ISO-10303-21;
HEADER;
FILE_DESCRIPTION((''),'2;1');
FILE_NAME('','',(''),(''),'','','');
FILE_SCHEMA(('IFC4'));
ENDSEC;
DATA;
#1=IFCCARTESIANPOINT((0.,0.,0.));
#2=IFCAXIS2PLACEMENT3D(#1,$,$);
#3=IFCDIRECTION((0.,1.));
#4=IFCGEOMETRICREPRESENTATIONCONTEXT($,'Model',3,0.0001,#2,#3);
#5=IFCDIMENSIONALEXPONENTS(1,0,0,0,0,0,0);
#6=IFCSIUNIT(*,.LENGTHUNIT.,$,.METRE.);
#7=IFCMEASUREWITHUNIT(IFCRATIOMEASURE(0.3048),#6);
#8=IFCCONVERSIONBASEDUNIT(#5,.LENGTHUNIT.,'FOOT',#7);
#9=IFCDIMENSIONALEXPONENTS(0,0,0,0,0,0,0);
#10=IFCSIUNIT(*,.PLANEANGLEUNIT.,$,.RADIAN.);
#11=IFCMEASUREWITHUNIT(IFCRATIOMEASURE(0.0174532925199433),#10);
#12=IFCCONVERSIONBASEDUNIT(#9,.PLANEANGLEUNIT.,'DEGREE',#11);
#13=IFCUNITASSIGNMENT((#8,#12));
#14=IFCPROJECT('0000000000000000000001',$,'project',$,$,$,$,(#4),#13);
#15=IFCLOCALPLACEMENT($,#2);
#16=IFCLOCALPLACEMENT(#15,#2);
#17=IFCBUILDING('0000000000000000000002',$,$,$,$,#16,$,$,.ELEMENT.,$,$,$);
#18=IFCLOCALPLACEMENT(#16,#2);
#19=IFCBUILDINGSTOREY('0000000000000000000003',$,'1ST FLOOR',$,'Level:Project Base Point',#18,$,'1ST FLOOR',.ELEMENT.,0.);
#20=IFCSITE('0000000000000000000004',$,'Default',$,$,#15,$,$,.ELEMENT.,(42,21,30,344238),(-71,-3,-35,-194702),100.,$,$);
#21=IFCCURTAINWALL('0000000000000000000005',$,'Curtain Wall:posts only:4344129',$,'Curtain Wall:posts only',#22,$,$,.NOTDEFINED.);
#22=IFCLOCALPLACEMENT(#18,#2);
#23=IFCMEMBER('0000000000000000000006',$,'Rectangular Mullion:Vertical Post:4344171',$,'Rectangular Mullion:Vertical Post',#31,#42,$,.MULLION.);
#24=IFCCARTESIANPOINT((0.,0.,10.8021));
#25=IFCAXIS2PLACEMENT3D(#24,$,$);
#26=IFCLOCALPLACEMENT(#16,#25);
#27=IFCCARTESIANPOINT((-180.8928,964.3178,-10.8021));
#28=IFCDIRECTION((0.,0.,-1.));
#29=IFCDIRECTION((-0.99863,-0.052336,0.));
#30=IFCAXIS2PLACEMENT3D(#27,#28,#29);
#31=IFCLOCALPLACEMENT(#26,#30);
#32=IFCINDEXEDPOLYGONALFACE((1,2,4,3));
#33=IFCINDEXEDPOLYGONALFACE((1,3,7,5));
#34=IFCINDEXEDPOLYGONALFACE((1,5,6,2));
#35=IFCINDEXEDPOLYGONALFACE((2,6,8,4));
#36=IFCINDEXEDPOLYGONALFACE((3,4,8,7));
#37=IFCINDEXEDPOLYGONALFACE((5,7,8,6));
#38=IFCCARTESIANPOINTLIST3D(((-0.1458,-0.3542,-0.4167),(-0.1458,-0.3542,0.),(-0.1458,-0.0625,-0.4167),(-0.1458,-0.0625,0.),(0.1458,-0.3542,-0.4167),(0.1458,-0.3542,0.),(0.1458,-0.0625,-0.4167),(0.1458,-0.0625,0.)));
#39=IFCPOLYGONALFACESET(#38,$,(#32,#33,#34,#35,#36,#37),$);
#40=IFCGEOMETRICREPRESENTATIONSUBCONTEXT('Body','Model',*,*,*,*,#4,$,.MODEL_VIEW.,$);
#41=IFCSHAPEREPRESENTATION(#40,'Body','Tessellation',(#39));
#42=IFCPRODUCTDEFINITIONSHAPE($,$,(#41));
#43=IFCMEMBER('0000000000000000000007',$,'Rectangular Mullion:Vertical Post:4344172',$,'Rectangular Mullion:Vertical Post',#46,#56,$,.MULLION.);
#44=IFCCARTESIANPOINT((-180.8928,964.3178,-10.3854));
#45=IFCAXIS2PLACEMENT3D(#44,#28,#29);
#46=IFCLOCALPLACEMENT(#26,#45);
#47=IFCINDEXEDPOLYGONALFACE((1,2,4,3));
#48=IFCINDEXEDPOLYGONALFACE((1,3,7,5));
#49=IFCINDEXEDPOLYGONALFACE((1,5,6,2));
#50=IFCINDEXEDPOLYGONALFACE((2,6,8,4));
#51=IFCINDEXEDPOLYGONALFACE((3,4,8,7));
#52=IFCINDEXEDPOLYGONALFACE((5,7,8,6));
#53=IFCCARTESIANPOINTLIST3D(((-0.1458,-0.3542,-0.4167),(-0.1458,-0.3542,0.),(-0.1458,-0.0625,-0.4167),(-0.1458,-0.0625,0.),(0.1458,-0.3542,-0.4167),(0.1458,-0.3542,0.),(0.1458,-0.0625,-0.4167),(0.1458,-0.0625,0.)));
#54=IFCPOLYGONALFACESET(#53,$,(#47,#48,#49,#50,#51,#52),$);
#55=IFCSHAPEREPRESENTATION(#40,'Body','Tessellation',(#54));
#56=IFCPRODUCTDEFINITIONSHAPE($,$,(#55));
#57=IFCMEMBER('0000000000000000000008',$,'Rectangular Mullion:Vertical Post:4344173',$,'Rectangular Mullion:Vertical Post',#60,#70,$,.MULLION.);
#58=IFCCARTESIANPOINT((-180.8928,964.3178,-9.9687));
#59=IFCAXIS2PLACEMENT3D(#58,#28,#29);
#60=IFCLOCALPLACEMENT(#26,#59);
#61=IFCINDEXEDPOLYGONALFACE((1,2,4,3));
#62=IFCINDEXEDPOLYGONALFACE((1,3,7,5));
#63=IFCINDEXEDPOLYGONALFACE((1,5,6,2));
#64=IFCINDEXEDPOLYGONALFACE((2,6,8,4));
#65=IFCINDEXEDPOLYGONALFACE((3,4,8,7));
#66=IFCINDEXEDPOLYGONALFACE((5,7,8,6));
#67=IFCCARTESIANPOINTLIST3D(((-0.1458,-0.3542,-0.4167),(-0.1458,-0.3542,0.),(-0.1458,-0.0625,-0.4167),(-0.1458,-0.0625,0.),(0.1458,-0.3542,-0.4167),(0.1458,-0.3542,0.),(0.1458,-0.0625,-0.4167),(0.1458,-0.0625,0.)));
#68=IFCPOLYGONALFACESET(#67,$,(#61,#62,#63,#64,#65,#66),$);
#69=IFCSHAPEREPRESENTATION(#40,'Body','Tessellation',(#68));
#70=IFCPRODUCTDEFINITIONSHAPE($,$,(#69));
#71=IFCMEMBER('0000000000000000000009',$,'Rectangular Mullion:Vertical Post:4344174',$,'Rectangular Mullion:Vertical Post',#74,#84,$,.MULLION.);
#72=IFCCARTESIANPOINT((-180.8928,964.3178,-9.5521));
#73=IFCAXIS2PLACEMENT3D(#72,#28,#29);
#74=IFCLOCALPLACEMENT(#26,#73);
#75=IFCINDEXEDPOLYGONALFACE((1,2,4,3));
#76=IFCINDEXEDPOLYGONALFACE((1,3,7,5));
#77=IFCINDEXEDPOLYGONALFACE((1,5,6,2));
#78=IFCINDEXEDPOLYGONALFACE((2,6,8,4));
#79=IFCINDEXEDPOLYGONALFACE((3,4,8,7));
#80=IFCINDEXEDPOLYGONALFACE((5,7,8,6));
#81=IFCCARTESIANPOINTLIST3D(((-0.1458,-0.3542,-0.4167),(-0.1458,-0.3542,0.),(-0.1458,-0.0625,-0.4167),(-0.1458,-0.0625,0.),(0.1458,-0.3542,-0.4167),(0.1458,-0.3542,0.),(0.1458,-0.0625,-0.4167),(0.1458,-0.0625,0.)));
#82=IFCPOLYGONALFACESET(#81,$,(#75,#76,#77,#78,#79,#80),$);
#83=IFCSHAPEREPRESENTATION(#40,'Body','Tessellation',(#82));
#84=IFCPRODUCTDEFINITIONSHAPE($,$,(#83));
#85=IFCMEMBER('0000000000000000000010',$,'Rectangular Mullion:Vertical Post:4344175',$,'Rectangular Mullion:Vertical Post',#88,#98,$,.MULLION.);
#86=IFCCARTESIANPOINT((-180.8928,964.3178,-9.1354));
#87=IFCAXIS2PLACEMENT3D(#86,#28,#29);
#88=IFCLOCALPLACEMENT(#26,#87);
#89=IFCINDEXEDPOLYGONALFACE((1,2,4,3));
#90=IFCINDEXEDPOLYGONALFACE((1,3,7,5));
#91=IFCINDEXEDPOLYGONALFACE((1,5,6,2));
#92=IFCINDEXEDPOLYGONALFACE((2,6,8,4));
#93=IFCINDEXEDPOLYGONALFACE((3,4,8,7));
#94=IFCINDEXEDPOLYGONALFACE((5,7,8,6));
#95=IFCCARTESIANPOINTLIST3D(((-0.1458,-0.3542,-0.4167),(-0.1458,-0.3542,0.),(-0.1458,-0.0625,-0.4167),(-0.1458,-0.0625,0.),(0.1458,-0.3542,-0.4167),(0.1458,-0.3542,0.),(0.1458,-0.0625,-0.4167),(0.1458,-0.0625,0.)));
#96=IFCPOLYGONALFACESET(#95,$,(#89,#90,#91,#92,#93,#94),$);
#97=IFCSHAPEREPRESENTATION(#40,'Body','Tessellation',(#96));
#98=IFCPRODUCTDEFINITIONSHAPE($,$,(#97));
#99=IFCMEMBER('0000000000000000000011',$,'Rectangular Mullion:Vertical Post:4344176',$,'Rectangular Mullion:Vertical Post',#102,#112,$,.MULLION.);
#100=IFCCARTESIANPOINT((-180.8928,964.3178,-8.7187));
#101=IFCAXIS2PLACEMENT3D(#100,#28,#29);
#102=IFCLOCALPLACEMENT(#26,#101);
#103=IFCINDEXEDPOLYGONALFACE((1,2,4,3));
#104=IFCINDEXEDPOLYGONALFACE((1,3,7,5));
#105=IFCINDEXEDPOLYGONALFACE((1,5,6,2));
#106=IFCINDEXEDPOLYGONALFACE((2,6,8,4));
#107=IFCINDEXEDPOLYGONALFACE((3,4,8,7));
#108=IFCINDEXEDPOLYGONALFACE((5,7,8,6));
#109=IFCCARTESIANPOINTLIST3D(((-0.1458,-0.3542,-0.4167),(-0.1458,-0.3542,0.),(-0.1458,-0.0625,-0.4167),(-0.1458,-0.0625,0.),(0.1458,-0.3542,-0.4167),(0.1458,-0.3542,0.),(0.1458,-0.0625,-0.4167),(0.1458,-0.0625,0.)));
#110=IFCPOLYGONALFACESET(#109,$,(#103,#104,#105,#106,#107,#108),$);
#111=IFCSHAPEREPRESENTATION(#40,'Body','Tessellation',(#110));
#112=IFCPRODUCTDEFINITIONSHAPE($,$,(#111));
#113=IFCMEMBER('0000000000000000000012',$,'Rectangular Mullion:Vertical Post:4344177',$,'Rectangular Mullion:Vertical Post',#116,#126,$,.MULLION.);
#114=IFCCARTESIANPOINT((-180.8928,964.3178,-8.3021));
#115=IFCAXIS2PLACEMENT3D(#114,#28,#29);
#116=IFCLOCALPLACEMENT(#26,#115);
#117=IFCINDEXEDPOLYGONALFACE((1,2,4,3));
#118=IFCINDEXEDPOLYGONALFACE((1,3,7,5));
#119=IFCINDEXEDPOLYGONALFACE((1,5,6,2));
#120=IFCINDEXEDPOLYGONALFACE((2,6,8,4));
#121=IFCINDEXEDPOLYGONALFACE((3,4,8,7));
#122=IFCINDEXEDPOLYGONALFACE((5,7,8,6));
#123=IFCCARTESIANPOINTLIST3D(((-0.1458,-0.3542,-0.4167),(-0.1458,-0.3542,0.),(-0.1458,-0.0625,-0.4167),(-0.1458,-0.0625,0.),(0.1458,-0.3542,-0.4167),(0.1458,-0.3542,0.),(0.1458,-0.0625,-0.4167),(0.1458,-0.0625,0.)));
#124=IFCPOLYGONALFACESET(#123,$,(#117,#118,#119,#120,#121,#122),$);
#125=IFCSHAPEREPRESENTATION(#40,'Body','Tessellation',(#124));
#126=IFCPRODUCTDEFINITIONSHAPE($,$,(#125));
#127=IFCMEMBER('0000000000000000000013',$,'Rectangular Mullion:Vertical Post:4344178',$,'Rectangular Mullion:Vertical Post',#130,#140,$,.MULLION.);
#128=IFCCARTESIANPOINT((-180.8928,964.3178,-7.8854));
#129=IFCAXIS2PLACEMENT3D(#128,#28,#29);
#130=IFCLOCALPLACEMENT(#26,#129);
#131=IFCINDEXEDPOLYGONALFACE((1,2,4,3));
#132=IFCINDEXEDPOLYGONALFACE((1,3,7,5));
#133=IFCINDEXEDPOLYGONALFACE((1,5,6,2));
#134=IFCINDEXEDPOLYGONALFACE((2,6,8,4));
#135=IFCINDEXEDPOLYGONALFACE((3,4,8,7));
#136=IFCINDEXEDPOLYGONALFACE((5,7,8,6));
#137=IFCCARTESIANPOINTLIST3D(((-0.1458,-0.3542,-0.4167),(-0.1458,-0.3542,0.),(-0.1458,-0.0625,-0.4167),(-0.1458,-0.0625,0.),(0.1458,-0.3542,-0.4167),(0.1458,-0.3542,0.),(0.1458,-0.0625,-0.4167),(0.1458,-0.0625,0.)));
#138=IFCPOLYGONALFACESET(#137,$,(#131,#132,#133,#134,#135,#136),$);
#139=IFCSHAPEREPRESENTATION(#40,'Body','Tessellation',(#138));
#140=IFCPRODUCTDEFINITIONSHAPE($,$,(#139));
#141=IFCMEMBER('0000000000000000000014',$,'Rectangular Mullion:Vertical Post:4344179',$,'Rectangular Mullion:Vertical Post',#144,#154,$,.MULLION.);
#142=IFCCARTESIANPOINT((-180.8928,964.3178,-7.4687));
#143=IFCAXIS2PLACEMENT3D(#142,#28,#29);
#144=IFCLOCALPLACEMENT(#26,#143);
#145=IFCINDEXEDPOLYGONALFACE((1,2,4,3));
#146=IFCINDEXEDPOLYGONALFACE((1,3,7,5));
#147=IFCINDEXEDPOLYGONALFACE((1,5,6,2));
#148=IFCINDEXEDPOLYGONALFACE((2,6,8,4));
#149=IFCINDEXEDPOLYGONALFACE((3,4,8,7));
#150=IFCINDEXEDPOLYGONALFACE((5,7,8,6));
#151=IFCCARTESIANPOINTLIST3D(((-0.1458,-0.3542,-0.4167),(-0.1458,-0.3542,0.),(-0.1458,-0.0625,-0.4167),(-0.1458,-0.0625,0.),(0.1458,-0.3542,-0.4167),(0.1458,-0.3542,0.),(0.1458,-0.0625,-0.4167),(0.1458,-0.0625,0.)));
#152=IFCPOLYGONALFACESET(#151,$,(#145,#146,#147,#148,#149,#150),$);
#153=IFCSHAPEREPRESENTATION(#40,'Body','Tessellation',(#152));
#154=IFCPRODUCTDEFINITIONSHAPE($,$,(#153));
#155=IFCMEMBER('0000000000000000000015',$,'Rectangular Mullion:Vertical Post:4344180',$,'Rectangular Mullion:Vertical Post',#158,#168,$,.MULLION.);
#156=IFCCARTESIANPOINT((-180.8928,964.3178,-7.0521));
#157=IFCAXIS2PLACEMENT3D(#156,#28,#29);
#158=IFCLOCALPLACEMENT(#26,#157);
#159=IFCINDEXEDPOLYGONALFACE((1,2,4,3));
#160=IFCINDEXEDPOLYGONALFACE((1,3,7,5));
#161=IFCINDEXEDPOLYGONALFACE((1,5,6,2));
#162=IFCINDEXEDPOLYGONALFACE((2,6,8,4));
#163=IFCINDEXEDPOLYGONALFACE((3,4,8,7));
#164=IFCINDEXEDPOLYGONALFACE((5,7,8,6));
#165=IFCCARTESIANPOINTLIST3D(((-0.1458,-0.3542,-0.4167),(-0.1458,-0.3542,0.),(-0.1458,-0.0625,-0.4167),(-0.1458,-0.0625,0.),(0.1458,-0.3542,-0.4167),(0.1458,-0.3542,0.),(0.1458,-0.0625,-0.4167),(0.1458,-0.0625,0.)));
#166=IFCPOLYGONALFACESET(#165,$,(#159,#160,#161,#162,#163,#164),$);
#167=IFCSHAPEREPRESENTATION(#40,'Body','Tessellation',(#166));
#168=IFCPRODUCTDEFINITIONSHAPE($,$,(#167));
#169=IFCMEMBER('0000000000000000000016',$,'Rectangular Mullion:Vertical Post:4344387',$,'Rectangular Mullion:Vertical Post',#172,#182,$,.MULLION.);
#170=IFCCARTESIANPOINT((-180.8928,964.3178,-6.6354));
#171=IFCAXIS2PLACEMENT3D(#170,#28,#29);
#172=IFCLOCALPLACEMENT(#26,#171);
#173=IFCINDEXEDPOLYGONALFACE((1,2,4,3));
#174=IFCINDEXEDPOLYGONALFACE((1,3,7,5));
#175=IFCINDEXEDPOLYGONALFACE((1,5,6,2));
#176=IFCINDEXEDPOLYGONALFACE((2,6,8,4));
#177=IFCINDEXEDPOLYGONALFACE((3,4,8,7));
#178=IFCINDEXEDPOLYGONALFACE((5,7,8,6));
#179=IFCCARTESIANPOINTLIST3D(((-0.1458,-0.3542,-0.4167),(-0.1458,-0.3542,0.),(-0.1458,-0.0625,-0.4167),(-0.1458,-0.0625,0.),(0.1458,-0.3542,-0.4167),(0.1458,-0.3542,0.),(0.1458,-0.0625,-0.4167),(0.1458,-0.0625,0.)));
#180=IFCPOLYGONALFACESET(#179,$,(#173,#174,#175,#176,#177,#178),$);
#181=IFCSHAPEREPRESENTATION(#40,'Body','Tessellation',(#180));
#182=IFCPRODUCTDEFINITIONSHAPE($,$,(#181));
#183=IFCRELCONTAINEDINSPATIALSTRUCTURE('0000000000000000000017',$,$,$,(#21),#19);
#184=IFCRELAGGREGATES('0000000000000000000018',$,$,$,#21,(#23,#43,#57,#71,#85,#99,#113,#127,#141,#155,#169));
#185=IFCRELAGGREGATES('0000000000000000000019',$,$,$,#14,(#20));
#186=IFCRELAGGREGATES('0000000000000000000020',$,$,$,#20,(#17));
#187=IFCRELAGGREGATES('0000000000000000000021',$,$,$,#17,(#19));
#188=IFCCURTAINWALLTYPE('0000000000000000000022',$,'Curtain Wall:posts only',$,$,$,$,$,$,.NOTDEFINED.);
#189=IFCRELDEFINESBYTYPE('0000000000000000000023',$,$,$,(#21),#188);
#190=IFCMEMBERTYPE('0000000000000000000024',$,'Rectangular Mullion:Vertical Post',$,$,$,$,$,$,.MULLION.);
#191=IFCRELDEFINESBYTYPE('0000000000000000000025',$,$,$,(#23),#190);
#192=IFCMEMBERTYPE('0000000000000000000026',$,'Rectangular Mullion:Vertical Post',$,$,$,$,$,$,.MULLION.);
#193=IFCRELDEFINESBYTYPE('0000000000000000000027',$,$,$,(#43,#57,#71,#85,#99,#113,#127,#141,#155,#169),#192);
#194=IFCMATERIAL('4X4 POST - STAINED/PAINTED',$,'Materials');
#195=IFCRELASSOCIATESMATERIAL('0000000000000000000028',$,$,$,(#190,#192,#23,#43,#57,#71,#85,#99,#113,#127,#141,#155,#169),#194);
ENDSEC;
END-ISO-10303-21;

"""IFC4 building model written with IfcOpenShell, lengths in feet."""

from ifc_helpers import new_model, entity, si_unit, converted_unit, direction, frame, origin, origin_2d_with_axis, place, context, subcontext, project, spatial, rectangle, extrude, source, transform, mapped, material, material_profile, profile_set, profile_usage, type_object, type_shapes, element, aggregate, save


model = new_model("IFC4")

# Units and contexts
model_context = context("Model", 3, precision=0.0001, world=origin(), true_north=direction((0.0, 1.0)))
body_context = subcontext(model_context, "Body", "Model", "MODEL_VIEW")
ifc_project = project(units=[converted_unit("LENGTHUNIT", "FOOT", entity("IfcRatioMeasure", 0.3048), si_unit("LENGTHUNIT", "METRE"), dimensions=[1, 0, 0, 0, 0, 0, 0]), converted_unit("PLANEANGLEUNIT", "DEGREE", entity("IfcRatioMeasure", 0.0174532925199433), si_unit("PLANEANGLEUNIT", "RADIAN"), dimensions=[0, 0, 0, 0, 0, 0, 0])], contexts=[model_context])

# Site, building, storey
site_placement = place(None, origin())
site = spatial("IfcSite", under=ifc_project, at=site_placement, Name="Default", CompositionType="ELEMENT", RefLatitude=(42, 21, 30, 344238), RefLongitude=(-71, -3, -35, -194702), RefElevation=100.0)
building_placement = place(site_placement, origin())
building = spatial("IfcBuilding", under=site, at=building_placement, CompositionType="ELEMENT")
storey_placement = place(building_placement, origin())
storey = spatial("IfcBuildingStorey", under=building, at=storey_placement, Name="1ST FLOOR", ObjectType="Level:Project Base Point", LongName="1ST FLOOR", CompositionType="ELEMENT", Elevation=0.0)

# Curtain wall, members
curtain_wall_type_1 = type_object("IfcCurtainWallType", Name="Curtain Wall:posts only", PredefinedType="NOTDEFINED")
curtain_wall_1_placement = place(storey_placement, origin())
curtain_wall_1 = element("IfcCurtainWall", 1, at=curtain_wall_1_placement, inside=storey, type_object=curtain_wall_type_1, Name="Curtain Wall:posts only:4344129", ObjectType="Curtain Wall:posts only", PredefinedType="NOTDEFINED")
ifc_material_1 = material(Name="4X4 POST - STAINED/PAINTED", Category="Materials")
ifc_material_profile_1 = material_profile(ifc_material_1, rectangle(XDim=0.2917, YDim=0.2917, at=origin_2d_with_axis()), Name="Vertical Post")
ifc_profile_set_1 = profile_set([ifc_material_profile_1], Name="Vertical Post")
ifc_profile_usage_1 = profile_usage(ifc_profile_set_1)
member_type_1 = type_object("IfcMemberType", Name="Rectangular Mullion:Vertical Post", PredefinedType="MULLION", material=ifc_profile_set_1)
shared_shape_1 = source(origin(), body_context, "Body", "SweptSolid", [
    extrude(rectangle(XDim=0.2917, YDim=0.2917, at=origin_2d_with_axis()), frame((0.0, -0.2083, -0.4167), z_axis=(0.0, 0.0, 1.0), x_axis=(0.0, -1.0, 0.0)), (0.0, 0.0, 1.0), 0.4167),
])
type_shapes(member_type_1, [shared_shape_1])
placement = place(building_placement, frame((0.0, 0.0, 10.8021)))
member_1_placement = place(placement, frame((-180.8928, 964.3178, -10.8021), z_axis=(0.0, 0.0, -1.0), x_axis=(-0.99863, -0.052336, 0.0)))
member_1 = element("IfcMember", 2, at=member_1_placement, type_object=member_type_1, material=ifc_profile_usage_1, Name="Rectangular Mullion:Vertical Post:4344171", ObjectType="Rectangular Mullion:Vertical Post", PredefinedType="MULLION", context=body_context, shape_type="MappedRepresentation", body=[
    mapped(shared_shape_1, transform((0.0, 0.0, 0.0), scale=1.0)),
])
ifc_profile_usage_2 = profile_usage(ifc_profile_set_1)
member_type_2 = type_object("IfcMemberType", Name="Rectangular Mullion:Vertical Post", PredefinedType="MULLION", material=ifc_profile_set_1)
shared_shape_2 = source(origin(), body_context, "Body", "SweptSolid", [
    extrude(rectangle(XDim=0.2917, YDim=0.2917, at=origin_2d_with_axis()), frame((0.0, -0.2083, -0.4167), z_axis=(0.0, 0.0, 1.0), x_axis=(0.0, -1.0, 0.0)), (0.0, 0.0, 1.0), 0.4167),
])
type_shapes(member_type_2, [shared_shape_2])
member_2_placement = place(placement, frame((-180.8928, 964.3178, -10.3854), z_axis=(0.0, 0.0, -1.0), x_axis=(-0.99863, -0.052336, 0.0)))
member_2 = element("IfcMember", 3, at=member_2_placement, type_object=member_type_2, material=ifc_profile_usage_2, Name="Rectangular Mullion:Vertical Post:4344172", ObjectType="Rectangular Mullion:Vertical Post", PredefinedType="MULLION", context=body_context, shape_type="MappedRepresentation", body=[
    mapped(shared_shape_2, transform((0.0, 0.0, 0.0), scale=1.0)),
])
ifc_profile_usage_3 = profile_usage(ifc_profile_set_1)
member_3_placement = place(placement, frame((-180.8928, 964.3178, -9.9687), z_axis=(0.0, 0.0, -1.0), x_axis=(-0.99863, -0.052336, 0.0)))
member_3 = element("IfcMember", 4, at=member_3_placement, type_object=member_type_2, material=ifc_profile_usage_3, Name="Rectangular Mullion:Vertical Post:4344173", ObjectType="Rectangular Mullion:Vertical Post", PredefinedType="MULLION", context=body_context, shape_type="MappedRepresentation", body=[
    mapped(shared_shape_2, transform((0.0, 0.0, 0.0), scale=1.0)),
])
ifc_profile_usage_4 = profile_usage(ifc_profile_set_1)
member_4_placement = place(placement, frame((-180.8928, 964.3178, -9.5521), z_axis=(0.0, 0.0, -1.0), x_axis=(-0.99863, -0.052336, 0.0)))
member_4 = element("IfcMember", 5, at=member_4_placement, type_object=member_type_2, material=ifc_profile_usage_4, Name="Rectangular Mullion:Vertical Post:4344174", ObjectType="Rectangular Mullion:Vertical Post", PredefinedType="MULLION", context=body_context, shape_type="MappedRepresentation", body=[
    mapped(shared_shape_2, transform((0.0, 0.0, 0.0), scale=1.0)),
])
ifc_profile_usage_5 = profile_usage(ifc_profile_set_1)
member_5_placement = place(placement, frame((-180.8928, 964.3178, -9.1354), z_axis=(0.0, 0.0, -1.0), x_axis=(-0.99863, -0.052336, 0.0)))
member_5 = element("IfcMember", 6, at=member_5_placement, type_object=member_type_2, material=ifc_profile_usage_5, Name="Rectangular Mullion:Vertical Post:4344175", ObjectType="Rectangular Mullion:Vertical Post", PredefinedType="MULLION", context=body_context, shape_type="MappedRepresentation", body=[
    mapped(shared_shape_2, transform((0.0, 0.0, 0.0), scale=1.0)),
])
ifc_profile_usage_6 = profile_usage(ifc_profile_set_1)
member_6_placement = place(placement, frame((-180.8928, 964.3178, -8.7187), z_axis=(0.0, 0.0, -1.0), x_axis=(-0.99863, -0.052336, 0.0)))
member_6 = element("IfcMember", 7, at=member_6_placement, type_object=member_type_2, material=ifc_profile_usage_6, Name="Rectangular Mullion:Vertical Post:4344176", ObjectType="Rectangular Mullion:Vertical Post", PredefinedType="MULLION", context=body_context, shape_type="MappedRepresentation", body=[
    mapped(shared_shape_2, transform((0.0, 0.0, 0.0), scale=1.0)),
])
ifc_profile_usage_7 = profile_usage(ifc_profile_set_1)
member_7_placement = place(placement, frame((-180.8928, 964.3178, -8.3021), z_axis=(0.0, 0.0, -1.0), x_axis=(-0.99863, -0.052336, 0.0)))
member_7 = element("IfcMember", 8, at=member_7_placement, type_object=member_type_2, material=ifc_profile_usage_7, Name="Rectangular Mullion:Vertical Post:4344177", ObjectType="Rectangular Mullion:Vertical Post", PredefinedType="MULLION", context=body_context, shape_type="MappedRepresentation", body=[
    mapped(shared_shape_2, transform((0.0, 0.0, 0.0), scale=1.0)),
])
ifc_profile_usage_8 = profile_usage(ifc_profile_set_1)
member_8_placement = place(placement, frame((-180.8928, 964.3178, -7.8854), z_axis=(0.0, 0.0, -1.0), x_axis=(-0.99863, -0.052336, 0.0)))
member_8 = element("IfcMember", 9, at=member_8_placement, type_object=member_type_2, material=ifc_profile_usage_8, Name="Rectangular Mullion:Vertical Post:4344178", ObjectType="Rectangular Mullion:Vertical Post", PredefinedType="MULLION", context=body_context, shape_type="MappedRepresentation", body=[
    mapped(shared_shape_2, transform((0.0, 0.0, 0.0), scale=1.0)),
])
ifc_profile_usage_9 = profile_usage(ifc_profile_set_1)
member_9_placement = place(placement, frame((-180.8928, 964.3178, -7.4687), z_axis=(0.0, 0.0, -1.0), x_axis=(-0.99863, -0.052336, 0.0)))
member_9 = element("IfcMember", 10, at=member_9_placement, type_object=member_type_2, material=ifc_profile_usage_9, Name="Rectangular Mullion:Vertical Post:4344179", ObjectType="Rectangular Mullion:Vertical Post", PredefinedType="MULLION", context=body_context, shape_type="MappedRepresentation", body=[
    mapped(shared_shape_2, transform((0.0, 0.0, 0.0), scale=1.0)),
])
ifc_profile_usage_10 = profile_usage(ifc_profile_set_1)
member_10_placement = place(placement, frame((-180.8928, 964.3178, -7.0521), z_axis=(0.0, 0.0, -1.0), x_axis=(-0.99863, -0.052336, 0.0)))
member_10 = element("IfcMember", 11, at=member_10_placement, type_object=member_type_2, material=ifc_profile_usage_10, Name="Rectangular Mullion:Vertical Post:4344180", ObjectType="Rectangular Mullion:Vertical Post", PredefinedType="MULLION", context=body_context, shape_type="MappedRepresentation", body=[
    mapped(shared_shape_2, transform((0.0, 0.0, 0.0), scale=1.0)),
])
ifc_profile_usage_11 = profile_usage(ifc_profile_set_1)
member_11_placement = place(placement, frame((-180.8928, 964.3178, -6.6354), z_axis=(0.0, 0.0, -1.0), x_axis=(-0.99863, -0.052336, 0.0)))
member_11 = element("IfcMember", 12, at=member_11_placement, type_object=member_type_2, material=ifc_profile_usage_11, Name="Rectangular Mullion:Vertical Post:4344387", ObjectType="Rectangular Mullion:Vertical Post", PredefinedType="MULLION", context=body_context, shape_type="MappedRepresentation", body=[
    mapped(shared_shape_2, transform((0.0, 0.0, 0.0), scale=1.0)),
])
aggregate(curtain_wall_1, [member_1, member_2, member_3, member_4, member_5, member_6, member_7, member_8, member_9, member_10, member_11])

save(model, "model.ifc")
